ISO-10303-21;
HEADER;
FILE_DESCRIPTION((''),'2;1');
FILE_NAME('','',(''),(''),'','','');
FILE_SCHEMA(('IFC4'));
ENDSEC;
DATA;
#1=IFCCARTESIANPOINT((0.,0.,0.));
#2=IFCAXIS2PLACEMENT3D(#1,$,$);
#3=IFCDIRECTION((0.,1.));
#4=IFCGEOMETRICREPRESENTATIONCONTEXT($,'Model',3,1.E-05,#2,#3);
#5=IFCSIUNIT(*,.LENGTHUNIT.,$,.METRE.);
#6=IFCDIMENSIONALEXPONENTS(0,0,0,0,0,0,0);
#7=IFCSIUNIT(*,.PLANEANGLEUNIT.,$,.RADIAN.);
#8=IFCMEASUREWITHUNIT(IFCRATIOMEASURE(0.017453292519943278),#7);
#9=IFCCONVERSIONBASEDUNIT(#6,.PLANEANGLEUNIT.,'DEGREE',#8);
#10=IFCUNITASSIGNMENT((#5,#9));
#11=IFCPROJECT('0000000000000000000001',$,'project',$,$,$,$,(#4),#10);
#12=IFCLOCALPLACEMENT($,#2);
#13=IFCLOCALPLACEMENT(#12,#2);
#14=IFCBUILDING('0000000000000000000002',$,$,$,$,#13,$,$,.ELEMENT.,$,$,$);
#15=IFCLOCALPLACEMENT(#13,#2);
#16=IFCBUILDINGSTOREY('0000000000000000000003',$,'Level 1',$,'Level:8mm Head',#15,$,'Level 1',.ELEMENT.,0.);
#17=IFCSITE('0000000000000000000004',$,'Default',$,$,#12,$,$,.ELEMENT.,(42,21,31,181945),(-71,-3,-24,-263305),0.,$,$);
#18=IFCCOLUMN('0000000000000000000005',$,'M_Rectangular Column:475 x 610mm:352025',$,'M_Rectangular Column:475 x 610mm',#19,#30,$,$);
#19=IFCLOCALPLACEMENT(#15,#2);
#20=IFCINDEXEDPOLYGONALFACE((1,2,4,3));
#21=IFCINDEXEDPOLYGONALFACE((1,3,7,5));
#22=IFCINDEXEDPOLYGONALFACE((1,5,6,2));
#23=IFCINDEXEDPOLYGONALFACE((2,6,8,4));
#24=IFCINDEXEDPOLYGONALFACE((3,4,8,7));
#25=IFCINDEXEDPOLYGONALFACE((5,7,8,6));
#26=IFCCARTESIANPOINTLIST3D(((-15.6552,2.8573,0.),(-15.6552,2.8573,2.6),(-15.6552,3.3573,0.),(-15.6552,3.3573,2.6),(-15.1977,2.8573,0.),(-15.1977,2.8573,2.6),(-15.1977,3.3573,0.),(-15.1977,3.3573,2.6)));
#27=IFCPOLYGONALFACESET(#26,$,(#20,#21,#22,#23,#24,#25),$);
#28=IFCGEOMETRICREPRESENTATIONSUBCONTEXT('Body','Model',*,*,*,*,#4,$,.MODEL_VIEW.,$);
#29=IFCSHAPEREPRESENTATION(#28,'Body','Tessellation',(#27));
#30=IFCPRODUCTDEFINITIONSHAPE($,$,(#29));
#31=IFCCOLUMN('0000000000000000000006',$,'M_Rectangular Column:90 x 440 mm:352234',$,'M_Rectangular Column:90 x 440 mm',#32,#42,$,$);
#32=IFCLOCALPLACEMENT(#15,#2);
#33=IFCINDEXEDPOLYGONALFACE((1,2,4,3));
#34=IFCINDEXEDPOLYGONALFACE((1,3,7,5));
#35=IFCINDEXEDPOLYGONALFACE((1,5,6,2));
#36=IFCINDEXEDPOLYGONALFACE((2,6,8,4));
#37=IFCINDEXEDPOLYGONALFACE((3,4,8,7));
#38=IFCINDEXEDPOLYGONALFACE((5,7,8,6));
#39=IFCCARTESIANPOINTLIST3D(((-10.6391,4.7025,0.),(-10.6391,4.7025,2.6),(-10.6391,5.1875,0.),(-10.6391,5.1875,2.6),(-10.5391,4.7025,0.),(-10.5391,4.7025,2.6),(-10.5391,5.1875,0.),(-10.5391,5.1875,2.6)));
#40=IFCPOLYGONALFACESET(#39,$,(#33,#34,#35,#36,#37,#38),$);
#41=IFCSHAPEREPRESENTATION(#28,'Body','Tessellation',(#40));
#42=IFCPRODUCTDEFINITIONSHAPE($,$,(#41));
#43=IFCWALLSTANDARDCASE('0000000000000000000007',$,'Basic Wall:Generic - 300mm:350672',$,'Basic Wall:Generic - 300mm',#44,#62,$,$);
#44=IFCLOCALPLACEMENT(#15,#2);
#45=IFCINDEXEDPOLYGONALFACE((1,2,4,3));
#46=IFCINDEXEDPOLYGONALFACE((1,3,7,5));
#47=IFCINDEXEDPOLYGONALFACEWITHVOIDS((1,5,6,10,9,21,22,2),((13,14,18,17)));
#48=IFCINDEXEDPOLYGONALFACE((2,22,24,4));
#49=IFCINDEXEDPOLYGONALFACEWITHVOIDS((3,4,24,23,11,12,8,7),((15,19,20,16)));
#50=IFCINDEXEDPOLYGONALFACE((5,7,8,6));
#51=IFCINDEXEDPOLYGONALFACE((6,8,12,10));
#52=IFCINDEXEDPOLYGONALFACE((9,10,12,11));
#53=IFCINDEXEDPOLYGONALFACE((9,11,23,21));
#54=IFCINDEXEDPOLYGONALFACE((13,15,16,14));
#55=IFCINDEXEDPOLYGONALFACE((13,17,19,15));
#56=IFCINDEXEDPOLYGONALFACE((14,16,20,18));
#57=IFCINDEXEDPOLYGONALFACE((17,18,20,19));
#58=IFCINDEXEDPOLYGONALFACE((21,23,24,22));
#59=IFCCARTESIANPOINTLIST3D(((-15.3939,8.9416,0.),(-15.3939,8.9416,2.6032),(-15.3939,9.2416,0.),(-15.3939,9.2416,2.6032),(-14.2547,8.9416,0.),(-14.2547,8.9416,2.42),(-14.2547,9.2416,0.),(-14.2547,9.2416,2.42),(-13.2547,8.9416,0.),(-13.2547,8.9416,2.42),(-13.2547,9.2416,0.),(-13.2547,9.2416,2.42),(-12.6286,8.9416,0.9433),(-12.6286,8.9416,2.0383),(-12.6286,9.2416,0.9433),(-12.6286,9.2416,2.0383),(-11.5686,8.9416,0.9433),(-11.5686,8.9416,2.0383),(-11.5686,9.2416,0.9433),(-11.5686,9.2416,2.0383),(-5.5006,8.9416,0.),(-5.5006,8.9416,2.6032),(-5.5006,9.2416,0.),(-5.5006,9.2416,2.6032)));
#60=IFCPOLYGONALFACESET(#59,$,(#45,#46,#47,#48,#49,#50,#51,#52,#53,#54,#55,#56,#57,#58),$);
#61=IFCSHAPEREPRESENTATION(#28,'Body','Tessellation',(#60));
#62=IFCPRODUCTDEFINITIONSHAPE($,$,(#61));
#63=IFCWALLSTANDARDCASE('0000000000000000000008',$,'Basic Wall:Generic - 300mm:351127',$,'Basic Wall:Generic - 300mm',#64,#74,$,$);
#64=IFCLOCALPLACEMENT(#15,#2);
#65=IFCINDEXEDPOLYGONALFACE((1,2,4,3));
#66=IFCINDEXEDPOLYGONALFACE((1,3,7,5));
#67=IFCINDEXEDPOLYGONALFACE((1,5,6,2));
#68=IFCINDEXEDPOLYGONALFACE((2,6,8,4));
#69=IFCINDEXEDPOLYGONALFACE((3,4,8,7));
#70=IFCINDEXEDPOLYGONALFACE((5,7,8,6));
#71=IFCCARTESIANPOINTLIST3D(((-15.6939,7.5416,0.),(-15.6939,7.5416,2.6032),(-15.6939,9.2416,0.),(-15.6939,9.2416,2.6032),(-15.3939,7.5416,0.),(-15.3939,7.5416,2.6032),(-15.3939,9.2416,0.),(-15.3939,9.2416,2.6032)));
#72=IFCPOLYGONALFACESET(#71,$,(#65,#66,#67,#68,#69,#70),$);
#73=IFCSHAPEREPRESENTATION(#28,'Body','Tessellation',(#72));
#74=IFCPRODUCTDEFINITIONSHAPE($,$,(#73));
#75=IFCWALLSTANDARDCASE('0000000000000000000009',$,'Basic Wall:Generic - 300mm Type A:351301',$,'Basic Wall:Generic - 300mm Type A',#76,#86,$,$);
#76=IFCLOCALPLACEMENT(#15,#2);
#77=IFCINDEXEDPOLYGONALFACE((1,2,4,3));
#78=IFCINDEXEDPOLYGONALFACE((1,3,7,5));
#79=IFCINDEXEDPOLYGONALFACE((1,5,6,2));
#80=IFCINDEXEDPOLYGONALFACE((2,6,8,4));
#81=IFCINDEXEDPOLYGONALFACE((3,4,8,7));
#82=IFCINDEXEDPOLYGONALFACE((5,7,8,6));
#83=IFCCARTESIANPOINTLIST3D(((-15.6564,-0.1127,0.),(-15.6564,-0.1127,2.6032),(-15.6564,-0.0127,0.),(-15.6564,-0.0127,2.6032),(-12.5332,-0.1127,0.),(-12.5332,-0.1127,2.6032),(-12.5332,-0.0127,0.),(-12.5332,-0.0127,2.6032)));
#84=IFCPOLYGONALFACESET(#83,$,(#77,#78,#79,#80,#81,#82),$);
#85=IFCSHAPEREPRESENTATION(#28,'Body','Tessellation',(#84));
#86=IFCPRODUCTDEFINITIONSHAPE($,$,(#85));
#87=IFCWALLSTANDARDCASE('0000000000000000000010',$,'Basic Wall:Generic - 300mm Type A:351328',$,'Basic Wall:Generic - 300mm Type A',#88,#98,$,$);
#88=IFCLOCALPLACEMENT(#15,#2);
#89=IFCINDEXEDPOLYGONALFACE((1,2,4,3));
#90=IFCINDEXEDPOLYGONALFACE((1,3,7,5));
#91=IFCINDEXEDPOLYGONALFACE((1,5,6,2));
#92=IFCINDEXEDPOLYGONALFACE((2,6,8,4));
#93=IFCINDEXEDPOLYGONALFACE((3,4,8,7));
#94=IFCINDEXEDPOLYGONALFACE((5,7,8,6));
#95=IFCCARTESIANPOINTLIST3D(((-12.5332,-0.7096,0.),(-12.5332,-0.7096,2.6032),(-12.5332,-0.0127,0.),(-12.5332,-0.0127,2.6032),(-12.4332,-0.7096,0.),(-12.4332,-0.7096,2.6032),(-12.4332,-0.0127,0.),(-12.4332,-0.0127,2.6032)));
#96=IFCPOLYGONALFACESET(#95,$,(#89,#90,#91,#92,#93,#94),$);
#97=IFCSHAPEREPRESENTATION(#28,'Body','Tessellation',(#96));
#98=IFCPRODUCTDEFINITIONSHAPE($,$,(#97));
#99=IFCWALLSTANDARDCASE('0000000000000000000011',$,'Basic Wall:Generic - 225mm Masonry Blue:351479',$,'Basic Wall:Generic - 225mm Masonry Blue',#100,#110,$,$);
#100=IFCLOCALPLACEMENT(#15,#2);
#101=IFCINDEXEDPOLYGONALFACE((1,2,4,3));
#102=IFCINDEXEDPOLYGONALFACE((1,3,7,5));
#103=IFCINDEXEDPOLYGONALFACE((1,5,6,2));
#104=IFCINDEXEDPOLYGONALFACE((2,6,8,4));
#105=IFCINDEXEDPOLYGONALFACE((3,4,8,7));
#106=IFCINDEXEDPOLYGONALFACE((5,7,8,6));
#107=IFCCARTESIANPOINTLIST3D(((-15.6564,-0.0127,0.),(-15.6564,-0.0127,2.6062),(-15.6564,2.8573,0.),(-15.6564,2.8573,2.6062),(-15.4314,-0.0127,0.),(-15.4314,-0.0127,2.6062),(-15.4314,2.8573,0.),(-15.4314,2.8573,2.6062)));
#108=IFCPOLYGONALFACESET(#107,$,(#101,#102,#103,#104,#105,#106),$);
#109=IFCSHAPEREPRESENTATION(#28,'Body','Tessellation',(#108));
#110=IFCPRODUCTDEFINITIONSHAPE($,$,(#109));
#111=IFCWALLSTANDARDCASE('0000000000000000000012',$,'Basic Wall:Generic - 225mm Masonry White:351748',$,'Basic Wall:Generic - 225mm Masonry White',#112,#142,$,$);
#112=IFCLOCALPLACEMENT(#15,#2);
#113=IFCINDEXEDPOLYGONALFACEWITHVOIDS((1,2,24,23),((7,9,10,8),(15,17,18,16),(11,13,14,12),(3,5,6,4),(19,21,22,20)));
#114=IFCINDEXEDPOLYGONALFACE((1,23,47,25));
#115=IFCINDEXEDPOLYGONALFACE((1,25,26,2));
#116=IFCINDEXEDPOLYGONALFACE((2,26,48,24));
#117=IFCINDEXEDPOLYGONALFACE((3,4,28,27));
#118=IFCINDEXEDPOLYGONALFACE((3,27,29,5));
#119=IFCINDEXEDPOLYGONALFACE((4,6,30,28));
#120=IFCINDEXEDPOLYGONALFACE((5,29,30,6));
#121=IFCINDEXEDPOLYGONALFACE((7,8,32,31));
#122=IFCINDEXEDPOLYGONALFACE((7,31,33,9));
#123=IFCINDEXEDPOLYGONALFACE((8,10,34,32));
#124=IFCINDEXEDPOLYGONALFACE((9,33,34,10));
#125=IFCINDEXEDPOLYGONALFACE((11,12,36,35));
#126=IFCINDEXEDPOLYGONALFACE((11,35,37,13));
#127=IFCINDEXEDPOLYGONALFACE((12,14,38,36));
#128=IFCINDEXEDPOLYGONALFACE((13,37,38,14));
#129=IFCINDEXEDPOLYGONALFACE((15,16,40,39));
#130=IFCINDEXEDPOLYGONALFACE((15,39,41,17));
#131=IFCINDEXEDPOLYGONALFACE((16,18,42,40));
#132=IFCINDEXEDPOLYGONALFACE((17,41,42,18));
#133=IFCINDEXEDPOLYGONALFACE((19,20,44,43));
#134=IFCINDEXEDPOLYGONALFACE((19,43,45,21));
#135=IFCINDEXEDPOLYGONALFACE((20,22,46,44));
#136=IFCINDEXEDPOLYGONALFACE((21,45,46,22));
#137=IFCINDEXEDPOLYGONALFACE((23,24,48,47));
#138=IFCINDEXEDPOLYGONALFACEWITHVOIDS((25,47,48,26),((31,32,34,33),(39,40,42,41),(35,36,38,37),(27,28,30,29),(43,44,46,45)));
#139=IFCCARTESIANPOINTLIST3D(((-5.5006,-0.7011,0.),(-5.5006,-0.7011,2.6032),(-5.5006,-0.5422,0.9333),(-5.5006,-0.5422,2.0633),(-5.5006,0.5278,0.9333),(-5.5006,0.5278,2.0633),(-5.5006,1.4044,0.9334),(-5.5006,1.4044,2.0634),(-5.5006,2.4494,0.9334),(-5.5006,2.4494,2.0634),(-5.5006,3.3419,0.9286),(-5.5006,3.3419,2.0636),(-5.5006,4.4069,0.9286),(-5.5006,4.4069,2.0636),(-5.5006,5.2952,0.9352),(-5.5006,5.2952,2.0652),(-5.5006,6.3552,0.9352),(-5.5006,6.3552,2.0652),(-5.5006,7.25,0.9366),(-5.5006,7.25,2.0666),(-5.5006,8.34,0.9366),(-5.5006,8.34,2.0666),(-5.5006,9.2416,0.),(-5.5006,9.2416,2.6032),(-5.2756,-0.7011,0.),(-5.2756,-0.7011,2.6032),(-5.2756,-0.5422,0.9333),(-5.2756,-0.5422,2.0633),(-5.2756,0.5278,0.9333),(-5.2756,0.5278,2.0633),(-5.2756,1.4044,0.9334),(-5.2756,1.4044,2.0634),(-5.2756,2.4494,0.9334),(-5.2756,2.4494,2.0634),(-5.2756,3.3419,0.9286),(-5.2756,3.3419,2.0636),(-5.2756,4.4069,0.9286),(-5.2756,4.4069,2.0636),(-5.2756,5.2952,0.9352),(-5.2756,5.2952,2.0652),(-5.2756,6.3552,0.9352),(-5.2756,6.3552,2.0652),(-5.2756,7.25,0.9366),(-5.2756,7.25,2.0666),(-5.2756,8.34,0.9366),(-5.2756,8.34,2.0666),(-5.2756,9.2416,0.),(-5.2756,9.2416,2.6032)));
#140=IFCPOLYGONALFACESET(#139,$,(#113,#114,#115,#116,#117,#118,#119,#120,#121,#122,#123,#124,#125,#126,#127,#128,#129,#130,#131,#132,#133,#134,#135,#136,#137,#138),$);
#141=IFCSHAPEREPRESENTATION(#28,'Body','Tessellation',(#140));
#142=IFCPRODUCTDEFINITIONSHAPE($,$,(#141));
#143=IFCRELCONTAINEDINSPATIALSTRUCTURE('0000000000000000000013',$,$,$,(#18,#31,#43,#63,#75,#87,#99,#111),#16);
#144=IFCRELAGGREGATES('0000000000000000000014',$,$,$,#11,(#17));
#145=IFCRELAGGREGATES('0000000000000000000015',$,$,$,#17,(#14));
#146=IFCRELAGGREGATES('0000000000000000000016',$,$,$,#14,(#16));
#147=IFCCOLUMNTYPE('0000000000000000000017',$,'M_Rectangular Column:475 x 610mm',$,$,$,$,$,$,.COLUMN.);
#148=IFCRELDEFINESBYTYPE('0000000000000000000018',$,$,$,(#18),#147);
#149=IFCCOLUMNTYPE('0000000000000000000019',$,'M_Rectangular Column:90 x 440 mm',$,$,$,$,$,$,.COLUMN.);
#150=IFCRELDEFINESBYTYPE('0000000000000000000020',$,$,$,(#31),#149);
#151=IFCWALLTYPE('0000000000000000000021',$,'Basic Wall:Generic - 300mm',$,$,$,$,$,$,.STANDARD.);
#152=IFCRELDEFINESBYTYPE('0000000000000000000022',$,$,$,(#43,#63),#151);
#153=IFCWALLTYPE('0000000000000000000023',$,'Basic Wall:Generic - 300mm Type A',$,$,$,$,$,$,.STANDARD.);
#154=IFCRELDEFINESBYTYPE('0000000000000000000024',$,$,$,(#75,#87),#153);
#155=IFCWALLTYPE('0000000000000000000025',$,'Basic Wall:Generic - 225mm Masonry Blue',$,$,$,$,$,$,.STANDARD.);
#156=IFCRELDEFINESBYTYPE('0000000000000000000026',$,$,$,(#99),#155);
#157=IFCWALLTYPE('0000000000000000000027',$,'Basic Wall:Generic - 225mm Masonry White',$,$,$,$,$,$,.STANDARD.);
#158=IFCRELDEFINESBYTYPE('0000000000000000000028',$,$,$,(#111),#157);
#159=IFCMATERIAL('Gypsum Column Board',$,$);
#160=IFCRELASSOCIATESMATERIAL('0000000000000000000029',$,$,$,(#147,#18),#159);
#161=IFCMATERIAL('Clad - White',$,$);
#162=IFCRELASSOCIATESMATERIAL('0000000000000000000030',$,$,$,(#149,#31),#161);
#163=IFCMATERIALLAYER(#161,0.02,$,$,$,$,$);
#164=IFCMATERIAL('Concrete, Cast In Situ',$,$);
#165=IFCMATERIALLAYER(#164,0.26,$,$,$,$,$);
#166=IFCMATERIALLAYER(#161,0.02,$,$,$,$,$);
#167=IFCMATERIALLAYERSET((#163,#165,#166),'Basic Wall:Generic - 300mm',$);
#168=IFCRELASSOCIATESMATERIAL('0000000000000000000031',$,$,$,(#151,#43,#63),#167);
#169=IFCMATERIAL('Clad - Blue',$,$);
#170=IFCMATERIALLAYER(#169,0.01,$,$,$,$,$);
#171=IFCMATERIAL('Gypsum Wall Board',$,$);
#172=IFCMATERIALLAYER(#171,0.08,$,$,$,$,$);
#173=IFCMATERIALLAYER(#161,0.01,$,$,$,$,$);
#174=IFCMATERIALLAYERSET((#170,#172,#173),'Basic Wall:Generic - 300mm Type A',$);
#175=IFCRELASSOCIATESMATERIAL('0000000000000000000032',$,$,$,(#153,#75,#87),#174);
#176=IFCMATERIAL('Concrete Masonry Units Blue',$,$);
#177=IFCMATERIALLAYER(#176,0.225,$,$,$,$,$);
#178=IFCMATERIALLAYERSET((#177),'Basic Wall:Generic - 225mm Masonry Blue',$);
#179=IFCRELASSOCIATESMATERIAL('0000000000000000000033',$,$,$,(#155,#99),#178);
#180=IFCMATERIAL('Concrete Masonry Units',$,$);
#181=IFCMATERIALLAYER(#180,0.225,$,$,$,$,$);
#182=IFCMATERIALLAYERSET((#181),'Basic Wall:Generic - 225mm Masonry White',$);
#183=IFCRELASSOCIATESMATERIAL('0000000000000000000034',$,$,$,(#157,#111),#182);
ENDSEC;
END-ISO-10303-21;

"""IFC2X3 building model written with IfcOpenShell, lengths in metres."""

from ifc_helpers import new_model, entity, si_unit, converted_unit, direction, frame, frame_2d, origin, origin_2d_with_axis, place, context, subcontext, project, spatial, rectangle, extrude, source, transform, mapped, material, layer, layer_set, layer_usage, type_object, type_shapes, element, save


model = new_model("IFC2X3")

# Units and contexts
model_context = context("Model", 3, precision=1e-05, world=origin(), true_north=direction((0.0, 1.0)))
body_context = subcontext(model_context, "Body", "Model", "MODEL_VIEW")
ifc_project = project(units=[si_unit("LENGTHUNIT", "METRE"), converted_unit("PLANEANGLEUNIT", "DEGREE", entity("IfcRatioMeasure", 0.017453292519943278), si_unit("PLANEANGLEUNIT", "RADIAN"), dimensions=[0, 0, 0, 0, 0, 0, 0])], contexts=[model_context])

# Site, building, storey
site_placement = place(None, origin())
site = spatial("IfcSite", under=ifc_project, at=site_placement, Name="Default", CompositionType="ELEMENT", RefLatitude=(42, 21, 31, 181945), RefLongitude=(-71, -3, -24, -263305), RefElevation=0.0)
building_placement = place(site_placement, origin())
building = spatial("IfcBuilding", under=site, at=building_placement, CompositionType="ELEMENT")
storey_placement = place(building_placement, origin())
storey = spatial("IfcBuildingStorey", under=building, at=storey_placement, Name="Level 1", ObjectType="Level:8mm Head", LongName="Level 1", CompositionType="ELEMENT", Elevation=0.0)

# Columns
ifc_material_1 = material(Name="Gypsum Column Board")
column_type_1 = type_object("IfcColumnType", Name="M_Rectangular Column:475 x 610mm", PredefinedType="COLUMN", material=ifc_material_1)
shared_shape_1 = source(origin(), body_context, "Body", "SweptSolid", [
    extrude(rectangle(XDim=0.5, YDim=0.4575, at=origin_2d_with_axis()), frame((-15.4264, 3.1073, 0.0), z_axis=(0.0, 0.0, 1.0), x_axis=(0.0, -1.0, 0.0)), (0.0, 0.0, 1.0), 2.6),
])
type_shapes(column_type_1, [shared_shape_1])
column_1_placement = place(storey_placement, origin())
element("IfcColumn", 1, at=column_1_placement, inside=storey, type_object=column_type_1, material=ifc_material_1, Name="M_Rectangular Column:475 x 610mm:352025", ObjectType="M_Rectangular Column:475 x 610mm", context=body_context, shape_type="MappedRepresentation", body=[
    mapped(shared_shape_1, transform((0.0, 0.0, 0.0), scale=1.0)),
])
ifc_material_2 = material(Name="Clad - White")
column_type_2 = type_object("IfcColumnType", Name="M_Rectangular Column:90 x 440 mm", PredefinedType="COLUMN", material=ifc_material_2)
shared_shape_2 = source(origin(), body_context, "Body", "SweptSolid", [
    extrude(rectangle(XDim=0.485, YDim=0.1, at=frame_2d((0.0, 0.0), x_axis=(1.0, 0.0))), frame((-10.5891, 4.945, 0.0), z_axis=(0.0, 0.0, 1.0), x_axis=(0.0, -1.0, 0.0)), (0.0, 0.0, 1.0), 2.6),
])
type_shapes(column_type_2, [shared_shape_2])
column_2_placement = place(storey_placement, origin())
element("IfcColumn", 2, at=column_2_placement, inside=storey, type_object=column_type_2, material=ifc_material_2, Name="M_Rectangular Column:90 x 440 mm:352234", ObjectType="M_Rectangular Column:90 x 440 mm", context=body_context, shape_type="MappedRepresentation", body=[
    mapped(shared_shape_2, transform((0.0, 0.0, 0.0), scale=1.0)),
])

# Wall, openings
ifc_layer_1 = layer(ifc_material_2, 0.02)
ifc_material_3 = material(Name="Concrete, Cast In Situ")
ifc_layer_2 = layer(ifc_material_3, 0.26)
ifc_layer_3 = layer(ifc_material_2, 0.02)
ifc_layer_set_1 = layer_set([ifc_layer_1, ifc_layer_2, ifc_layer_3], Name="Basic Wall:Generic - 300mm")
ifc_layer_usage_1 = layer_usage(ifc_layer_set_1, "AXIS2", "NEGATIVE", 0.15)
wall_type_1 = type_object("IfcWallType", Name="Basic Wall:Generic - 300mm", PredefinedType="STANDARD", material=ifc_layer_set_1)
wall_1_placement = place(storey_placement, frame((-15.3939, 9.0916, 0.0)))
wall_1 = element("IfcWallStandardCase", 3, at=wall_1_placement, inside=storey, type_object=wall_type_1, material=ifc_layer_usage_1, Name="Basic Wall:Generic - 300mm:350672", ObjectType="Basic Wall:Generic - 300mm", context=body_context, shape_type="SweptSolid", body=[
    extrude(rectangle(XDim=9.8934, YDim=0.3, at=frame_2d((4.9467, 0.0), x_axis=(1.0, 0.0))), origin(), (0.0, 0.0, 1.0), 2.6032),
])
opening_1_placement = place(wall_1_placement, frame((2.1393, 0.15, 0.0)))
element("IfcOpeningElement", 4, at=opening_1_placement, cuts=wall_1, ObjectType="Opening", context=body_context, shape_type="SweptSolid", body=[
    extrude(rectangle(XDim=2.42, YDim=1.0, at=frame_2d((1.21, 0.5), x_axis=(1.0, 0.0))), frame((0.0, 0.0, 0.0), z_axis=(0.0, -1.0, 0.0), x_axis=(0.0, 0.0, 1.0)), (0.0, 0.0, 1.0), 0.3),
])
opening_2_placement = place(wall_1_placement, frame((3.8253, 0.15, 0.9433)))
element("IfcOpeningElement", 5, at=opening_2_placement, cuts=wall_1, ObjectType="Opening", context=body_context, shape_type="SweptSolid", body=[
    extrude(rectangle(XDim=1.095, YDim=1.06, at=frame_2d((0.5475, 0.53), x_axis=(1.0, 0.0))), frame((0.0, 0.0, 0.0), z_axis=(0.0, -1.0, 0.0), x_axis=(0.0, 0.0, 1.0)), (0.0, 0.0, 1.0), 0.3),
])

# Walls
ifc_layer_usage_2 = layer_usage(ifc_layer_set_1, "AXIS2", "NEGATIVE", 0.15)
wall_2_placement = place(storey_placement, frame((-15.5439, 9.2416, 0.0), z_axis=(0.0, 0.0, 1.0), x_axis=(0.0, -1.0, 0.0)))
element("IfcWallStandardCase", 6, at=wall_2_placement, inside=storey, type_object=wall_type_1, material=ifc_layer_usage_2, Name="Basic Wall:Generic - 300mm:351127", ObjectType="Basic Wall:Generic - 300mm", context=body_context, shape_type="SweptSolid", body=[
    extrude(rectangle(XDim=1.7, YDim=0.3, at=frame_2d((0.85, 0.0), x_axis=(-1.0, 0.0))), origin(), (0.0, 0.0, 1.0), 2.6032),
])
ifc_material_4 = material(Name="Clad - Blue")
ifc_layer_4 = layer(ifc_material_4, 0.01)
ifc_material_5 = material(Name="Gypsum Wall Board")
ifc_layer_5 = layer(ifc_material_5, 0.08)
ifc_layer_6 = layer(ifc_material_2, 0.01)
ifc_layer_set_2 = layer_set([ifc_layer_4, ifc_layer_5, ifc_layer_6], Name="Basic Wall:Generic - 300mm Type A")
ifc_layer_usage_3 = layer_usage(ifc_layer_set_2, "AXIS2", "NEGATIVE", 0.05)
wall_type_2 = type_object("IfcWallType", Name="Basic Wall:Generic - 300mm Type A", PredefinedType="STANDARD", material=ifc_layer_set_2)
wall_3_placement = place(storey_placement, frame((-15.6564, -0.0627, 0.0)))
element("IfcWallStandardCase", 7, at=wall_3_placement, inside=storey, type_object=wall_type_2, material=ifc_layer_usage_3, Name="Basic Wall:Generic - 300mm Type A:351301", ObjectType="Basic Wall:Generic - 300mm Type A", context=body_context, shape_type="SweptSolid", body=[
    extrude(rectangle(XDim=3.1233, YDim=0.1, at=frame_2d((1.5616, 0.0), x_axis=(-1.0, 0.0))), origin(), (0.0, 0.0, 1.0), 2.6032),
])
ifc_layer_usage_4 = layer_usage(ifc_layer_set_2, "AXIS2", "NEGATIVE", 0.05)
wall_4_placement = place(storey_placement, frame((-12.4832, -0.0127, 0.0), z_axis=(0.0, 0.0, 1.0), x_axis=(0.0, -1.0, 0.0)))
element("IfcWallStandardCase", 8, at=wall_4_placement, inside=storey, type_object=wall_type_2, material=ifc_layer_usage_4, Name="Basic Wall:Generic - 300mm Type A:351328", ObjectType="Basic Wall:Generic - 300mm Type A", context=body_context, shape_type="SweptSolid", body=[
    extrude(rectangle(XDim=0.6969, YDim=0.1, at=frame_2d((0.3484, 0.0), x_axis=(-1.0, 0.0))), origin(), (0.0, 0.0, 1.0), 2.6032),
])
ifc_material_6 = material(Name="Concrete Masonry Units Blue")
ifc_layer_7 = layer(ifc_material_6, 0.225)
ifc_layer_set_3 = layer_set([ifc_layer_7], Name="Basic Wall:Generic - 225mm Masonry Blue")
ifc_layer_usage_5 = layer_usage(ifc_layer_set_3, "AXIS2", "NEGATIVE", 0.1125)
wall_type_3 = type_object("IfcWallType", Name="Basic Wall:Generic - 225mm Masonry Blue", PredefinedType="STANDARD", material=ifc_layer_set_3)
wall_5_placement = place(storey_placement, frame((-15.5439, -0.0127, 0.0), z_axis=(0.0, 0.0, 1.0), x_axis=(0.0, 1.0, 0.0)))
element("IfcWallStandardCase", 9, at=wall_5_placement, inside=storey, type_object=wall_type_3, material=ifc_layer_usage_5, Name="Basic Wall:Generic - 225mm Masonry Blue:351479", ObjectType="Basic Wall:Generic - 225mm Masonry Blue", context=body_context, shape_type="SweptSolid", body=[
    extrude(rectangle(XDim=2.87, YDim=0.225, at=frame_2d((1.435, 0.0), x_axis=(-1.0, 0.0))), origin(), (0.0, 0.0, 1.0), 2.6062),
])

# Wall, openings
ifc_material_7 = material(Name="Concrete Masonry Units")
ifc_layer_8 = layer(ifc_material_7, 0.225)
ifc_layer_set_4 = layer_set([ifc_layer_8], Name="Basic Wall:Generic - 225mm Masonry White")
ifc_layer_usage_6 = layer_usage(ifc_layer_set_4, "AXIS2", "NEGATIVE", 0.1125)
wall_type_4 = type_object("IfcWallType", Name="Basic Wall:Generic - 225mm Masonry White", PredefinedType="STANDARD", material=ifc_layer_set_4)
wall_6_placement = place(storey_placement, frame((-5.3881, 9.2416, 0.0), z_axis=(0.0, 0.0, 1.0), x_axis=(0.0, -1.0, 0.0)))
wall_6 = element("IfcWallStandardCase", 10, at=wall_6_placement, inside=storey, type_object=wall_type_4, material=ifc_layer_usage_6, Name="Basic Wall:Generic - 225mm Masonry White:351748", ObjectType="Basic Wall:Generic - 225mm Masonry White", context=body_context, shape_type="SweptSolid", body=[
    extrude(rectangle(XDim=9.9428, YDim=0.225, at=frame_2d((4.9714, 0.0), x_axis=(-1.0, 0.0))), origin(), (0.0, 0.0, 1.0), 2.6032),
])
opening_3_placement = place(wall_6_placement, frame((2.8864, -0.1125, 0.9352)))
element("IfcOpeningElement", 11, at=opening_3_placement, cuts=wall_6, ObjectType="Opening", context=body_context, shape_type="SweptSolid", body=[
    extrude(rectangle(XDim=1.13, YDim=1.06, at=frame_2d((0.565, 0.53), x_axis=(1.0, 0.0))), frame((0.0, 0.0, 0.0), z_axis=(0.0, 1.0, 0.0), x_axis=(0.0, 0.0, 1.0)), (0.0, 0.0, 1.0), 0.225),
])
opening_4_placement = place(wall_6_placement, frame((4.8348, -0.1125, 0.9286)))
element("IfcOpeningElement", 12, at=opening_4_placement, cuts=wall_6, ObjectType="Opening", context=body_context, shape_type="SweptSolid", body=[
    extrude(rectangle(XDim=1.135, YDim=1.065, at=frame_2d((0.5675, 0.5325), x_axis=(1.0, 0.0))), frame((0.0, 0.0, 0.0), z_axis=(0.0, 1.0, 0.0), x_axis=(0.0, 0.0, 1.0)), (0.0, 0.0, 1.0), 0.225),
])
opening_5_placement = place(wall_6_placement, frame((6.7923, -0.1125, 0.9334)))
element("IfcOpeningElement", 13, at=opening_5_placement, cuts=wall_6, ObjectType="Opening", context=body_context, shape_type="SweptSolid", body=[
    extrude(rectangle(XDim=1.13, YDim=1.045, at=frame_2d((0.565, 0.5225), x_axis=(1.0, 0.0))), frame((0.0, 0.0, 0.0), z_axis=(0.0, 1.0, 0.0), x_axis=(0.0, 0.0, 1.0)), (0.0, 0.0, 1.0), 0.225),
])
opening_6_placement = place(wall_6_placement, frame((8.7138, -0.1125, 0.9333)))
element("IfcOpeningElement", 14, at=opening_6_placement, cuts=wall_6, ObjectType="Opening", context=body_context, shape_type="SweptSolid", body=[
    extrude(rectangle(XDim=1.13, YDim=1.07, at=frame_2d((0.565, 0.535), x_axis=(1.0, 0.0))), frame((0.0, 0.0, 0.0), z_axis=(0.0, 1.0, 0.0), x_axis=(0.0, 0.0, 1.0)), (0.0, 0.0, 1.0), 0.225),
])
opening_7_placement = place(wall_6_placement, frame((0.9017, -0.1125, 0.9366)))
element("IfcOpeningElement", 15, at=opening_7_placement, cuts=wall_6, ObjectType="Opening", context=body_context, shape_type="SweptSolid", body=[
    extrude(rectangle(XDim=1.13, YDim=1.09, at=frame_2d((0.565, 0.545), x_axis=(1.0, 0.0))), frame((0.0, 0.0, 0.0), z_axis=(0.0, 1.0, 0.0), x_axis=(0.0, 0.0, 1.0)), (0.0, 0.0, 1.0), 0.225),
])

save(model, "model.ifc")
